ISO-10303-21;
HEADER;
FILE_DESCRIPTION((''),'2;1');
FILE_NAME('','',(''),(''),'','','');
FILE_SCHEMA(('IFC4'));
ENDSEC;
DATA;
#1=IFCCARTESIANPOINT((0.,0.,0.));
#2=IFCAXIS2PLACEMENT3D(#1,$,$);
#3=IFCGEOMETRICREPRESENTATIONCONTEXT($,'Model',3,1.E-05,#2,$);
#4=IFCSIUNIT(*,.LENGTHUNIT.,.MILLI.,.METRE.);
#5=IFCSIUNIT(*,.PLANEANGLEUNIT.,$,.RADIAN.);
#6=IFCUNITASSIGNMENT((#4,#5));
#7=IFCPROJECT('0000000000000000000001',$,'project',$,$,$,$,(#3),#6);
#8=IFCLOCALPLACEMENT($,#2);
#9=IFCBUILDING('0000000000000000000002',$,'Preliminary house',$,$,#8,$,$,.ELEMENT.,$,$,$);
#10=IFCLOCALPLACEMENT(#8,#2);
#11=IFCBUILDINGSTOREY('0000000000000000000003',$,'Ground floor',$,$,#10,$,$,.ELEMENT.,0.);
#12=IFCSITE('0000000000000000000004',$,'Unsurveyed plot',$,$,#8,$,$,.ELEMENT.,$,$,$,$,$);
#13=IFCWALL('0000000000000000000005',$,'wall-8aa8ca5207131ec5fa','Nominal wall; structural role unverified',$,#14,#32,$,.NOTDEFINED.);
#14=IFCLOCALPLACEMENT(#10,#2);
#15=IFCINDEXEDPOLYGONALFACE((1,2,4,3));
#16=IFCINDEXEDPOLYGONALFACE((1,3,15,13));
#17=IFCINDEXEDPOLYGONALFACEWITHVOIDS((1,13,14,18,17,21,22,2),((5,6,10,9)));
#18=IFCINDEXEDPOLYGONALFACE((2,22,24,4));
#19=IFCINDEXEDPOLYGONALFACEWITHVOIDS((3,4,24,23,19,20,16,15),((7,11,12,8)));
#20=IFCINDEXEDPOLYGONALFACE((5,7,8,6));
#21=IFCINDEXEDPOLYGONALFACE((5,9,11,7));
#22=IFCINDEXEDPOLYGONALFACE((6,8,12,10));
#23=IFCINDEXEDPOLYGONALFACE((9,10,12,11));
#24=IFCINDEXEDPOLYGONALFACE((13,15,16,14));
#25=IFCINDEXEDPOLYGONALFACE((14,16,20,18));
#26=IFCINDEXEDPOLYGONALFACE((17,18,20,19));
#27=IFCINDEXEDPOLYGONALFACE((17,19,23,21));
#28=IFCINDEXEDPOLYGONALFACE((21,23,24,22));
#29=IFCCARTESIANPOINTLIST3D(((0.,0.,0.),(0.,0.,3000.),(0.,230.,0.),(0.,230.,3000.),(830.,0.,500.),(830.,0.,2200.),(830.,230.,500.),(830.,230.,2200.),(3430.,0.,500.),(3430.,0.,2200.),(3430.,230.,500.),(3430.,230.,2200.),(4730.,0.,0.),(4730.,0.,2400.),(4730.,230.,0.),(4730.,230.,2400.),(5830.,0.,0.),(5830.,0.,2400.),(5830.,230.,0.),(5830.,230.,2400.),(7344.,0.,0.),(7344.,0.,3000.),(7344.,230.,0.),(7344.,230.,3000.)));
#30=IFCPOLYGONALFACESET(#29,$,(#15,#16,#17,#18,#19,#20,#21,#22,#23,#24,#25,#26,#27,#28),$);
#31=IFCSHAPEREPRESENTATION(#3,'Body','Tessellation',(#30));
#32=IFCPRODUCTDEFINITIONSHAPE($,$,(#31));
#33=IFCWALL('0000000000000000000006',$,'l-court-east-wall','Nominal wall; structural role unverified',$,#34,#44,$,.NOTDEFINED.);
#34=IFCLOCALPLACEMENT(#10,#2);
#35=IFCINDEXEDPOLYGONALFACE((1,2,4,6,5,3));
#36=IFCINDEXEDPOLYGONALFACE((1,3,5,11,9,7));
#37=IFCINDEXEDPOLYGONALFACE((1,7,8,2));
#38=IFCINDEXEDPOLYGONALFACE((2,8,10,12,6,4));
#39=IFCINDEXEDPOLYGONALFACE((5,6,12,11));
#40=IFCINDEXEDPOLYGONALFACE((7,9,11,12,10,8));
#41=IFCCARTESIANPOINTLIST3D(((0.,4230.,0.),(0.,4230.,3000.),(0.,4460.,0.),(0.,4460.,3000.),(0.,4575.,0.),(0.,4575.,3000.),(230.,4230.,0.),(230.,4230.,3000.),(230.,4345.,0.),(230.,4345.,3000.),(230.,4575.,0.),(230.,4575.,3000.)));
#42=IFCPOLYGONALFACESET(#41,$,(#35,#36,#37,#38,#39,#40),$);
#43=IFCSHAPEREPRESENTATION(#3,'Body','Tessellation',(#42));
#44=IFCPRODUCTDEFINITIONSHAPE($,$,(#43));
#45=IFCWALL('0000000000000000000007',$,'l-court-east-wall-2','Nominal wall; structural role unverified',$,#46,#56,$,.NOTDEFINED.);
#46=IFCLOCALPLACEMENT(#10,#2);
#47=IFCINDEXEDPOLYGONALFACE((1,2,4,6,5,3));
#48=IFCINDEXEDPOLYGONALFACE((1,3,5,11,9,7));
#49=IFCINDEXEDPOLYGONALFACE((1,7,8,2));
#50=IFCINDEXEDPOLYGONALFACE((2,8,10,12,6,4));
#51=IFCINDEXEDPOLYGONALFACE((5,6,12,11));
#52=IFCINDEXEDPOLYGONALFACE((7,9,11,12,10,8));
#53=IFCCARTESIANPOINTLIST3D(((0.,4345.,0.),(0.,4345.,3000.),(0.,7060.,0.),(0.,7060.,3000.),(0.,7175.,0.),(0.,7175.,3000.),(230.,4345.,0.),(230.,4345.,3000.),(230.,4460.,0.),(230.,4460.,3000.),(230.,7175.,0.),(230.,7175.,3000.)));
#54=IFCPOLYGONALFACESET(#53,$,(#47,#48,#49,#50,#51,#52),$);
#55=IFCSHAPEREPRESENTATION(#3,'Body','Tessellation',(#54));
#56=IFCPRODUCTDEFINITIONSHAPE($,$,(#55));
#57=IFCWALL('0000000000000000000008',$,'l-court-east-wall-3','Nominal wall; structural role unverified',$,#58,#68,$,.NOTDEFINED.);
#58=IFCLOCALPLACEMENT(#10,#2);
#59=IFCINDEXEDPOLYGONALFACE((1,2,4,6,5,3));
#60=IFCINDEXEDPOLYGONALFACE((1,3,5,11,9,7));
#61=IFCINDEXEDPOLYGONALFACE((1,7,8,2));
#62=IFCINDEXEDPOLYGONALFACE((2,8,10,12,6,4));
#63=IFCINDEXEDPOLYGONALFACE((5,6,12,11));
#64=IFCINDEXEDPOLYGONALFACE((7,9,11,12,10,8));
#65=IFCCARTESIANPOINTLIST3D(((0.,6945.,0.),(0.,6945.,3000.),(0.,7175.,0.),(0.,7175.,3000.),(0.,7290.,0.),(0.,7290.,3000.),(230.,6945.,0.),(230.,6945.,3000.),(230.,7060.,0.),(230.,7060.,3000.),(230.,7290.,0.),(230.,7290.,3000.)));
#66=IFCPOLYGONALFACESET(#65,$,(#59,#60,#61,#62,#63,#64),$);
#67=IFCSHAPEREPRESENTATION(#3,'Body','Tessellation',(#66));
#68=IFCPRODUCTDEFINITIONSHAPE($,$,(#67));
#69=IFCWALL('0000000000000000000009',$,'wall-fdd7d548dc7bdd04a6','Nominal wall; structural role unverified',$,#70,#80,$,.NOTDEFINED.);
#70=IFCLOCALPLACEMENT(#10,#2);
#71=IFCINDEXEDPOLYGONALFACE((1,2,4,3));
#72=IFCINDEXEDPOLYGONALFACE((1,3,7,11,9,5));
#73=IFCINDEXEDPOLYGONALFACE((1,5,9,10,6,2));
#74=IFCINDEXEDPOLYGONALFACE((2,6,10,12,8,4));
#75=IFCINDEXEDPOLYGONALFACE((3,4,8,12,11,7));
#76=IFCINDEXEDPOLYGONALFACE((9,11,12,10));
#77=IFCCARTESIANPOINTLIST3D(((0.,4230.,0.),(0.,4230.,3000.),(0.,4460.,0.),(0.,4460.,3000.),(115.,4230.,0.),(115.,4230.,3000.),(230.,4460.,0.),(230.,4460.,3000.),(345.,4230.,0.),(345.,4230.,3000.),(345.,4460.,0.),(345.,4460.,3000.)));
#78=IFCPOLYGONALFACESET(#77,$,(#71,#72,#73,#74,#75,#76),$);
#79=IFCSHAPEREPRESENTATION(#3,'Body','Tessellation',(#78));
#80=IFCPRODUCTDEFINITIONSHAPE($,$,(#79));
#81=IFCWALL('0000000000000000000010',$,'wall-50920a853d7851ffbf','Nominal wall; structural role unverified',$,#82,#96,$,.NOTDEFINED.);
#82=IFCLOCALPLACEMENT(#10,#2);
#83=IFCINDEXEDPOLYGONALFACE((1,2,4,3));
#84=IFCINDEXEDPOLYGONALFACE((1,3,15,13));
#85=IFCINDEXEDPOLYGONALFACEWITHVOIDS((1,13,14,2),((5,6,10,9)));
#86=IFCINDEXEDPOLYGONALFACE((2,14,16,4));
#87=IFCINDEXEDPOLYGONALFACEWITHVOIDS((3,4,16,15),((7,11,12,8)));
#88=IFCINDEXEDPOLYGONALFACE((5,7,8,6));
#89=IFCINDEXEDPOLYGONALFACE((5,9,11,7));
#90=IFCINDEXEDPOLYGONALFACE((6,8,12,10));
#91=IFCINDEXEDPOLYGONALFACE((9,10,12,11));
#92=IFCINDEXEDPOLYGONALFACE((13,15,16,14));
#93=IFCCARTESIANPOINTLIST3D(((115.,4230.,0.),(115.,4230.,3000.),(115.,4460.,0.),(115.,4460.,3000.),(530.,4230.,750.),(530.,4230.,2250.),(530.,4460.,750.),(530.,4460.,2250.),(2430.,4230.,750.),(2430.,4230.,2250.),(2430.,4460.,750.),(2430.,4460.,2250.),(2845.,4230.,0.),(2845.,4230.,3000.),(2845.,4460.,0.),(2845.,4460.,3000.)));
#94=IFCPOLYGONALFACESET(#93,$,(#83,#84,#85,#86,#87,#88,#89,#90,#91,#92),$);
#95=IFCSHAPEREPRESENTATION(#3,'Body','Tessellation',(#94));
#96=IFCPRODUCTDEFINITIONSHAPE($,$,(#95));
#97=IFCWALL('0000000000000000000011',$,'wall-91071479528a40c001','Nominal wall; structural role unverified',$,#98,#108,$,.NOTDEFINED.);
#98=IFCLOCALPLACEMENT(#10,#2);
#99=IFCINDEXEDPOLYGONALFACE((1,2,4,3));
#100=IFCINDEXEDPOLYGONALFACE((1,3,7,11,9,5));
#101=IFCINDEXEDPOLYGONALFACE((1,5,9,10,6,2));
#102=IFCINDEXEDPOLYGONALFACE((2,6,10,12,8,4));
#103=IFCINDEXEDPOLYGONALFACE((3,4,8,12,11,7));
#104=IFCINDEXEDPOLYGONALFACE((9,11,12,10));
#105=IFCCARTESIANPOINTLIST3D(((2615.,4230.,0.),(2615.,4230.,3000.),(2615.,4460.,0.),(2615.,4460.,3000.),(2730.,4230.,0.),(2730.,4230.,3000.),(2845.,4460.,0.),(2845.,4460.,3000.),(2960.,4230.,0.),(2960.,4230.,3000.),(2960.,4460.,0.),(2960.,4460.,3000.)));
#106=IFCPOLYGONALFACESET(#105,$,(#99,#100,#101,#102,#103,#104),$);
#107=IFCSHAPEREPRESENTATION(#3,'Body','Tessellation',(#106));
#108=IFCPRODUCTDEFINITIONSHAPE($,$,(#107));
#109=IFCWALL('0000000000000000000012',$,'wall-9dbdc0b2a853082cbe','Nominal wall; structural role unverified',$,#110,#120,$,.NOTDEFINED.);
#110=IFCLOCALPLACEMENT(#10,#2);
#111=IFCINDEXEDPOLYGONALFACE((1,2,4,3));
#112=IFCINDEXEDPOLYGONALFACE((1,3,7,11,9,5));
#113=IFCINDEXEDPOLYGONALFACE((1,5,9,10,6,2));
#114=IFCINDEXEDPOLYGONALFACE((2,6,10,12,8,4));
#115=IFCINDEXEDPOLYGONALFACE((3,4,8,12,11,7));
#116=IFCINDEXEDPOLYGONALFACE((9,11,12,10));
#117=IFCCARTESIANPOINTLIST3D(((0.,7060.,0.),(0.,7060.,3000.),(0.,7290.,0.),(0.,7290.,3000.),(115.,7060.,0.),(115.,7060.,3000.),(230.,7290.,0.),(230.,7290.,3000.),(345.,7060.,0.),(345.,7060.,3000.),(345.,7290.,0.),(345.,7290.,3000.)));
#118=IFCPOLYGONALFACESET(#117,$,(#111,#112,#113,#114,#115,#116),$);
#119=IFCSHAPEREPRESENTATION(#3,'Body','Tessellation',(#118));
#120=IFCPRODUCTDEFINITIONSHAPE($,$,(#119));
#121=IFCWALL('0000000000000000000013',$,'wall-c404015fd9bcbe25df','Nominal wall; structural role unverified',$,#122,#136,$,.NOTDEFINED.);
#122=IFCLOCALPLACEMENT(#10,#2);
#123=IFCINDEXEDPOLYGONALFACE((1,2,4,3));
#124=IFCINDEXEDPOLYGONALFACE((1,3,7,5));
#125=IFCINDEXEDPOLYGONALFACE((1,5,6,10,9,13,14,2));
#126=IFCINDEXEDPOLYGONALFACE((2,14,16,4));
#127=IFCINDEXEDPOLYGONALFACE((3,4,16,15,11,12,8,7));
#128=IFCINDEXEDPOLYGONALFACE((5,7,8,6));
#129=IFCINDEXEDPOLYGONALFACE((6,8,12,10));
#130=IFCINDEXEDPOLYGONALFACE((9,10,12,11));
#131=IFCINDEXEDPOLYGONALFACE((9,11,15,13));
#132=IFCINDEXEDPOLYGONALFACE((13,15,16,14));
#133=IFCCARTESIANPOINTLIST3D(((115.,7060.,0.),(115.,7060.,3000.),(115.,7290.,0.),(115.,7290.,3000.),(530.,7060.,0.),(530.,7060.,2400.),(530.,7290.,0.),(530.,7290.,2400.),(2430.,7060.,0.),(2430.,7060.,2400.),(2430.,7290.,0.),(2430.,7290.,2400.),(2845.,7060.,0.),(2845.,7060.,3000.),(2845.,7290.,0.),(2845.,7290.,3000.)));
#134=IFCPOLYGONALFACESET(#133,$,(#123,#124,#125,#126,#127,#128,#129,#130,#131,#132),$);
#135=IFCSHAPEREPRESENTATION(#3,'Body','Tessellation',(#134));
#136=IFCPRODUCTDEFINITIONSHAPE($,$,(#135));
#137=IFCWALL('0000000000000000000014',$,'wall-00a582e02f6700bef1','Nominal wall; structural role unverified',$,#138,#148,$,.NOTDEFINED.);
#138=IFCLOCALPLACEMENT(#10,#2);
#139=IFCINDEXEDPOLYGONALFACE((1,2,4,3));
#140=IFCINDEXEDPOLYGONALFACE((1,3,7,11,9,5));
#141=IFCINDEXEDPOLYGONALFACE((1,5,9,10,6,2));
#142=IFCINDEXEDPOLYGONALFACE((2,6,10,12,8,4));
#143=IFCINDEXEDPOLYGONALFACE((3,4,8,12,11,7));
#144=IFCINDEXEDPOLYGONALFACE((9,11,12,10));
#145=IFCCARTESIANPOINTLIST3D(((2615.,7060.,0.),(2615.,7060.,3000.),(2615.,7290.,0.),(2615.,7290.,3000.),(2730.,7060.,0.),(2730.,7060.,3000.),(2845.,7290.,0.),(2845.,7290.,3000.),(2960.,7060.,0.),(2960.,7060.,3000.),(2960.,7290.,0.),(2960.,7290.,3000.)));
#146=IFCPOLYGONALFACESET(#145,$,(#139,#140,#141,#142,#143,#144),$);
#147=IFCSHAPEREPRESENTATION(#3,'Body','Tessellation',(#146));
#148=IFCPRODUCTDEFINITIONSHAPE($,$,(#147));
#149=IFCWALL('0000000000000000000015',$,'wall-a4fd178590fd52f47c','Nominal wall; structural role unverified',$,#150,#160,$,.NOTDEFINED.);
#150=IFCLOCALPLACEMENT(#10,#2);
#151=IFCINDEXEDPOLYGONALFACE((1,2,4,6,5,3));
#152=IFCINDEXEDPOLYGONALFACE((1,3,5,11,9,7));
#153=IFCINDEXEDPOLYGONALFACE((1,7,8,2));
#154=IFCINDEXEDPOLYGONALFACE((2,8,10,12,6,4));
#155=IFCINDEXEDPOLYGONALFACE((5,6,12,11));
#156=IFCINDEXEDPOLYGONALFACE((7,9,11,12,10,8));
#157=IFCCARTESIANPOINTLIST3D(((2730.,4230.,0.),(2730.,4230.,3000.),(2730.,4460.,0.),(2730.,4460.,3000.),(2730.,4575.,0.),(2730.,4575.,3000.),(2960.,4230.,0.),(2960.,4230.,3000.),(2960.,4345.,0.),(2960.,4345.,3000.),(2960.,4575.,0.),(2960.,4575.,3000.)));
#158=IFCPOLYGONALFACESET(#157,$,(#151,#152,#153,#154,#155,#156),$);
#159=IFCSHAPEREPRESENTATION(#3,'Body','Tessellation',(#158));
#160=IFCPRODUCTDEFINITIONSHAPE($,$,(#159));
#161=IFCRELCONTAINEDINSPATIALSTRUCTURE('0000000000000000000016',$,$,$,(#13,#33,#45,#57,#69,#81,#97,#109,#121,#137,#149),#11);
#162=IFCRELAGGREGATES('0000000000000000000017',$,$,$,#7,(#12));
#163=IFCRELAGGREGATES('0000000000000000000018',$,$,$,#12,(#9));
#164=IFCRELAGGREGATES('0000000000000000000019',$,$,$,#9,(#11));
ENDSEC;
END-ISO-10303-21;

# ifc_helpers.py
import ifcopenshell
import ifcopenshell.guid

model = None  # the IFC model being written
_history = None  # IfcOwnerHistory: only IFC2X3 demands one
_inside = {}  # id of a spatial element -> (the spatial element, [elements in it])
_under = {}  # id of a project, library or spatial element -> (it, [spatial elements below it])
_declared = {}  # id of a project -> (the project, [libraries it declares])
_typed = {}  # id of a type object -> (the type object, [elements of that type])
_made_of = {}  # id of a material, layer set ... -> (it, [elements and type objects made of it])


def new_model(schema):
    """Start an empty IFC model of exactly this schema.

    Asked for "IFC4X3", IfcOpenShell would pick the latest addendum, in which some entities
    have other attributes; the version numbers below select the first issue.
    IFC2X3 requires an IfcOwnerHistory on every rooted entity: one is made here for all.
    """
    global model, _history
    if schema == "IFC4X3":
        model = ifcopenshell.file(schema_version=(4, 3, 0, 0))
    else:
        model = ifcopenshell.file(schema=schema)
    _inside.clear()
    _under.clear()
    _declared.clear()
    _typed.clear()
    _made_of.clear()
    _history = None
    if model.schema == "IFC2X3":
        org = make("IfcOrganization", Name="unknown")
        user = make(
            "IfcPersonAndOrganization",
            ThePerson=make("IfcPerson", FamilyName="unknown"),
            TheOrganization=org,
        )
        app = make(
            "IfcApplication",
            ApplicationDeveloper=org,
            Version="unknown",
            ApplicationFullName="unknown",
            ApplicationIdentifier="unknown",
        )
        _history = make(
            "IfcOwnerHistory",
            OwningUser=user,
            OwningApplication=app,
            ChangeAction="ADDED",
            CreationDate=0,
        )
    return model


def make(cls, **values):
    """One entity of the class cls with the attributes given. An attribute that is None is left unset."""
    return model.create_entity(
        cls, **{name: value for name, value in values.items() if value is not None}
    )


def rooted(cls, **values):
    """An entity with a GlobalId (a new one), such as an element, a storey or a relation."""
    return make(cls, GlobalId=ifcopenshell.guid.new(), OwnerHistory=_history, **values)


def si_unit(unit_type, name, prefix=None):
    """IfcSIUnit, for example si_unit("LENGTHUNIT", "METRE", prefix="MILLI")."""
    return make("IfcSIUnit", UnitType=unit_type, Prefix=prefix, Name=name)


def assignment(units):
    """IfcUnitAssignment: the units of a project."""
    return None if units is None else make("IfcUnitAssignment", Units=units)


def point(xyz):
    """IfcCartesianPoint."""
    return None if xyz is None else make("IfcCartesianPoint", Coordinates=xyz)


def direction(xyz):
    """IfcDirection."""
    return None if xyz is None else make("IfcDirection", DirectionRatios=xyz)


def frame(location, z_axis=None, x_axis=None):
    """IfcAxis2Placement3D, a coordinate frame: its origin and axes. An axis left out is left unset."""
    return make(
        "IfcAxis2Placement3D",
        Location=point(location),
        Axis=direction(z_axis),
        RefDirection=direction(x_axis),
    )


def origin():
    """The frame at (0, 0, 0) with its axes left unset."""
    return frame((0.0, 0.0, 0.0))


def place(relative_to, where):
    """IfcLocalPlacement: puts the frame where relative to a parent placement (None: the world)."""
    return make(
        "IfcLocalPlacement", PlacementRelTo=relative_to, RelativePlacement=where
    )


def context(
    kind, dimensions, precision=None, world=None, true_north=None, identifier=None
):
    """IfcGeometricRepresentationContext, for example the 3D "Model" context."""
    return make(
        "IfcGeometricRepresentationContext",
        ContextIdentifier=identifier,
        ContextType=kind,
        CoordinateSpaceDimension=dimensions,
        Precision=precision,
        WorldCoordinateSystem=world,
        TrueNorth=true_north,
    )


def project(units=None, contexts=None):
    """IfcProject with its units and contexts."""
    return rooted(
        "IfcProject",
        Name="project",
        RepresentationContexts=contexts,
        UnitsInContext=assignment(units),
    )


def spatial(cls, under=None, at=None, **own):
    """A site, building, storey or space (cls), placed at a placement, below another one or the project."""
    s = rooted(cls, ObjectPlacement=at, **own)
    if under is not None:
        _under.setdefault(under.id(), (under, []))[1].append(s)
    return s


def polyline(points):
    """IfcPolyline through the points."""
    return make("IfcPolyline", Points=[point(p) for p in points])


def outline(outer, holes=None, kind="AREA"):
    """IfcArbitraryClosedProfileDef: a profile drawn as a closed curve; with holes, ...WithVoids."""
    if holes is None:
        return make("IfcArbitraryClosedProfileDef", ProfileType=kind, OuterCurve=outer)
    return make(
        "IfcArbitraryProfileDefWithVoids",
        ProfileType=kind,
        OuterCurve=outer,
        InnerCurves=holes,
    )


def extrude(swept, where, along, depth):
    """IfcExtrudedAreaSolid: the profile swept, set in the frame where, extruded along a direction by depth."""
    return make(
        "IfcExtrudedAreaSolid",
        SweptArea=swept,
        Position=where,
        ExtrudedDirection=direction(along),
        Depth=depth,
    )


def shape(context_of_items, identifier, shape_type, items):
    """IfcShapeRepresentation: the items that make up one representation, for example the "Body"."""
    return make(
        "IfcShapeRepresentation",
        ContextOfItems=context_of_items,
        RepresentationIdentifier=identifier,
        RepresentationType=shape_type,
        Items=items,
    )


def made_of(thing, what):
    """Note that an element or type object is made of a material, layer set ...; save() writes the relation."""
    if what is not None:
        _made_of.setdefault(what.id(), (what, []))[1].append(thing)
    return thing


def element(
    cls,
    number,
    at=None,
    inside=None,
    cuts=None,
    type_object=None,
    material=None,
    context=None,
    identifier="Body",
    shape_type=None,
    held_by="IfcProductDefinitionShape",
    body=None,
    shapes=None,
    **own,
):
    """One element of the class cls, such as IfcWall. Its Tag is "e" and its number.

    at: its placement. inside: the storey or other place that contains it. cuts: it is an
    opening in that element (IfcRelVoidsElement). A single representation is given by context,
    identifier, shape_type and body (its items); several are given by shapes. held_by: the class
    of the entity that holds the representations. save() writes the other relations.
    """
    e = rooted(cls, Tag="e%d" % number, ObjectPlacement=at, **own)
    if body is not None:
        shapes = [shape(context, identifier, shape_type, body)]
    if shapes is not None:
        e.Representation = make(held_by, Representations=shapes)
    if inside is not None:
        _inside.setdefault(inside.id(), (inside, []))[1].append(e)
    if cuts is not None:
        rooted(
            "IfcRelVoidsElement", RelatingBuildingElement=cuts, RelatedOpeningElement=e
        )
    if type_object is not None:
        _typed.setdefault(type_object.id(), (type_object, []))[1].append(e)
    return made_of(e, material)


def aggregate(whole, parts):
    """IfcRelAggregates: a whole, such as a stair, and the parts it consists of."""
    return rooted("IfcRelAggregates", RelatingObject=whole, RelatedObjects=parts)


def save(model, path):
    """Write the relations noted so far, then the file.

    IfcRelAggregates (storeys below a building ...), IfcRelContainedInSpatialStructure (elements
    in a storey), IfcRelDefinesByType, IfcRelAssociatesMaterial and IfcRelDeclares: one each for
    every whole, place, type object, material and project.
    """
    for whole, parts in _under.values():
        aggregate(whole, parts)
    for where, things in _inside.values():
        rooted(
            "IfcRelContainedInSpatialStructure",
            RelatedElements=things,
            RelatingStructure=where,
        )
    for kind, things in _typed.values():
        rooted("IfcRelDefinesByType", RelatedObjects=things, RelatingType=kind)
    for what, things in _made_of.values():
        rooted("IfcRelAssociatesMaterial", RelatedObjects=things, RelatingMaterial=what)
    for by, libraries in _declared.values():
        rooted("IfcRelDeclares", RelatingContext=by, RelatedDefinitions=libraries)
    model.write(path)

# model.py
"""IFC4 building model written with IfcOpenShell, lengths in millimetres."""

from ifc_helpers import new_model, si_unit, frame, origin, place, context, project, spatial, polyline, outline, extrude, element, save


model = new_model("IFC4")

# Units and contexts
model_context = context("Model", 3, precision=1e-05, world=origin())
ifc_project = project(units=[si_unit("LENGTHUNIT", "METRE", prefix="MILLI"), si_unit("PLANEANGLEUNIT", "RADIAN")], contexts=[model_context])

# Site, building, storey
placement_1 = place(None, origin())
site = spatial("IfcSite", under=ifc_project, at=placement_1, Name="Unsurveyed plot", CompositionType="ELEMENT")
building = spatial("IfcBuilding", under=site, at=placement_1, Name="Preliminary house", CompositionType="ELEMENT")
placement_2 = place(placement_1, origin())
storey = spatial("IfcBuildingStorey", under=building, at=placement_2, Name="Ground floor", CompositionType="ELEMENT", Elevation=0.0)

# Wall, openings
wall_1 = element("IfcWall", 1, at=placement_2, inside=storey, Name="wall-8aa8ca5207131ec5fa", Description="Nominal wall; structural role unverified", PredefinedType="NOTDEFINED", context=model_context, shape_type="SweptSolid", body=[
    extrude(outline(polyline([(7229.0, 230.0), (7344.0, 230.0), (7344.0, 0.0), (115.0, 0.0), (0.0, 0.0), (0.0, 230.0), (7229.0, 230.0)])), origin(), (0.0, 0.0, 1.0), 3000.0),
])
element("IfcOpeningElement", 2, at=placement_2, cuts=wall_1, PredefinedType="OPENING", context=model_context, shape_type="SweptSolid", body=[
    extrude(outline(polyline([(4730.0, -415.0), (5830.0, -415.0), (5830.0, 645.0), (4730.0, 645.0), (4730.0, -415.0)])), origin(), (0.0, 0.0, 1.0), 2400.0),
])
element("IfcOpeningElement", 3, at=placement_2, cuts=wall_1, PredefinedType="OPENING", context=model_context, shape_type="SweptSolid", body=[
    extrude(outline(polyline([(830.0, -415.0), (3430.0, -415.0), (3430.0, 645.0), (830.0, 645.0), (830.0, -415.0)])), frame((0.0, 0.0, 500.0)), (0.0, 0.0, 1.0), 1700.0),
])

# Walls
element("IfcWall", 4, at=placement_2, inside=storey, Name="l-court-east-wall", Description="Nominal wall; structural role unverified", PredefinedType="NOTDEFINED", context=model_context, shape_type="SweptSolid", body=[
    extrude(outline(polyline([(0.0, 4460.0), (0.0, 4575.0), (230.0, 4575.0), (230.0, 4345.0), (230.0, 4230.0), (0.0, 4230.0), (0.0, 4460.0)])), origin(), (0.0, 0.0, 1.0), 3000.0),
])
element("IfcWall", 5, at=placement_2, inside=storey, Name="l-court-east-wall-2", Description="Nominal wall; structural role unverified", PredefinedType="NOTDEFINED", context=model_context, shape_type="SweptSolid", body=[
    extrude(outline(polyline([(0.0, 7060.0), (0.0, 7175.0), (230.0, 7175.0), (230.0, 4460.0), (230.0, 4345.0), (0.0, 4345.0), (0.0, 7060.0)])), origin(), (0.0, 0.0, 1.0), 3000.0),
])
element("IfcWall", 6, at=placement_2, inside=storey, Name="l-court-east-wall-3", Description="Nominal wall; structural role unverified", PredefinedType="NOTDEFINED", context=model_context, shape_type="SweptSolid", body=[
    extrude(outline(polyline([(0.0, 7175.0), (0.0, 7290.0), (230.0, 7290.0), (230.0, 7060.0), (230.0, 6945.0), (0.0, 6945.0), (0.0, 7175.0)])), origin(), (0.0, 0.0, 1.0), 3000.0),
])
element("IfcWall", 7, at=placement_2, inside=storey, Name="wall-fdd7d548dc7bdd04a6", Description="Nominal wall; structural role unverified", PredefinedType="NOTDEFINED", context=model_context, shape_type="SweptSolid", body=[
    extrude(outline(polyline([(230.0, 4460.0), (345.0, 4460.0), (345.0, 4230.0), (115.0, 4230.0), (0.0, 4230.0), (0.0, 4460.0), (230.0, 4460.0)])), origin(), (0.0, 0.0, 1.0), 3000.0),
])

# Wall, opening
wall_2 = element("IfcWall", 8, at=placement_2, inside=storey, Name="wall-50920a853d7851ffbf", Description="Nominal wall; structural role unverified", PredefinedType="NOTDEFINED", context=model_context, shape_type="SweptSolid", body=[
    extrude(outline(polyline([(2730.0, 4460.0), (2845.0, 4460.0), (2845.0, 4230.0), (230.0, 4230.0), (115.0, 4230.0), (115.0, 4460.0), (2730.0, 4460.0)])), origin(), (0.0, 0.0, 1.0), 3000.0),
])
element("IfcOpeningElement", 9, at=placement_2, cuts=wall_2, PredefinedType="OPENING", context=model_context, shape_type="SweptSolid", body=[
    extrude(outline(polyline([(530.0, 3815.0), (2430.0, 3815.0), (2430.0, 4875.0), (530.0, 4875.0), (530.0, 3815.0)])), frame((0.0, 0.0, 750.0)), (0.0, 0.0, 1.0), 1500.0),
])

# Wall
element("IfcWall", 10, at=placement_2, inside=storey, Name="wall-91071479528a40c001", Description="Nominal wall; structural role unverified", PredefinedType="NOTDEFINED", context=model_context, shape_type="SweptSolid", body=[
    extrude(outline(polyline([(2845.0, 4460.0), (2960.0, 4460.0), (2960.0, 4230.0), (2730.0, 4230.0), (2615.0, 4230.0), (2615.0, 4460.0), (2845.0, 4460.0)])), origin(), (0.0, 0.0, 1.0), 3000.0),
])

# Wall
element("IfcWall", 11, at=placement_2, inside=storey, Name="wall-9dbdc0b2a853082cbe", Description="Nominal wall; structural role unverified", PredefinedType="NOTDEFINED", context=model_context, shape_type="SweptSolid", body=[
    extrude(outline(polyline([(230.0, 7290.0), (345.0, 7290.0), (345.0, 7060.0), (115.0, 7060.0), (0.0, 7060.0), (0.0, 7290.0), (230.0, 7290.0)])), origin(), (0.0, 0.0, 1.0), 3000.0),
])

# Wall, opening
wall_3 = element("IfcWall", 12, at=placement_2, inside=storey, Name="wall-c404015fd9bcbe25df", Description="Nominal wall; structural role unverified", PredefinedType="NOTDEFINED", context=model_context, shape_type="SweptSolid", body=[
    extrude(outline(polyline([(2730.0, 7290.0), (2845.0, 7290.0), (2845.0, 7060.0), (230.0, 7060.0), (115.0, 7060.0), (115.0, 7290.0), (2730.0, 7290.0)])), origin(), (0.0, 0.0, 1.0), 3000.0),
])
element("IfcOpeningElement", 13, at=placement_2, cuts=wall_3, PredefinedType="OPENING", context=model_context, shape_type="SweptSolid", body=[
    extrude(outline(polyline([(530.0, 6645.0), (2430.0, 6645.0), (2430.0, 7705.0), (530.0, 7705.0), (530.0, 6645.0)])), origin(), (0.0, 0.0, 1.0), 2400.0),
])

# Wall
element("IfcWall", 14, at=placement_2, inside=storey, Name="wall-00a582e02f6700bef1", Description="Nominal wall; structural role unverified", PredefinedType="NOTDEFINED", context=model_context, shape_type="SweptSolid", body=[
    extrude(outline(polyline([(2845.0, 7290.0), (2960.0, 7290.0), (2960.0, 7060.0), (2730.0, 7060.0), (2615.0, 7060.0), (2615.0, 7290.0), (2845.0, 7290.0)])), origin(), (0.0, 0.0, 1.0), 3000.0),
])

# Wall
element("IfcWall", 15, at=placement_2, inside=storey, Name="wall-a4fd178590fd52f47c", Description="Nominal wall; structural role unverified", PredefinedType="NOTDEFINED", context=model_context, shape_type="SweptSolid", body=[
    extrude(outline(polyline([(2730.0, 4460.0), (2730.0, 4575.0), (2960.0, 4575.0), (2960.0, 4345.0), (2960.0, 4230.0), (2730.0, 4230.0), (2730.0, 4460.0)])), origin(), (0.0, 0.0, 1.0), 3000.0),
])

save(model, "model.ifc")
